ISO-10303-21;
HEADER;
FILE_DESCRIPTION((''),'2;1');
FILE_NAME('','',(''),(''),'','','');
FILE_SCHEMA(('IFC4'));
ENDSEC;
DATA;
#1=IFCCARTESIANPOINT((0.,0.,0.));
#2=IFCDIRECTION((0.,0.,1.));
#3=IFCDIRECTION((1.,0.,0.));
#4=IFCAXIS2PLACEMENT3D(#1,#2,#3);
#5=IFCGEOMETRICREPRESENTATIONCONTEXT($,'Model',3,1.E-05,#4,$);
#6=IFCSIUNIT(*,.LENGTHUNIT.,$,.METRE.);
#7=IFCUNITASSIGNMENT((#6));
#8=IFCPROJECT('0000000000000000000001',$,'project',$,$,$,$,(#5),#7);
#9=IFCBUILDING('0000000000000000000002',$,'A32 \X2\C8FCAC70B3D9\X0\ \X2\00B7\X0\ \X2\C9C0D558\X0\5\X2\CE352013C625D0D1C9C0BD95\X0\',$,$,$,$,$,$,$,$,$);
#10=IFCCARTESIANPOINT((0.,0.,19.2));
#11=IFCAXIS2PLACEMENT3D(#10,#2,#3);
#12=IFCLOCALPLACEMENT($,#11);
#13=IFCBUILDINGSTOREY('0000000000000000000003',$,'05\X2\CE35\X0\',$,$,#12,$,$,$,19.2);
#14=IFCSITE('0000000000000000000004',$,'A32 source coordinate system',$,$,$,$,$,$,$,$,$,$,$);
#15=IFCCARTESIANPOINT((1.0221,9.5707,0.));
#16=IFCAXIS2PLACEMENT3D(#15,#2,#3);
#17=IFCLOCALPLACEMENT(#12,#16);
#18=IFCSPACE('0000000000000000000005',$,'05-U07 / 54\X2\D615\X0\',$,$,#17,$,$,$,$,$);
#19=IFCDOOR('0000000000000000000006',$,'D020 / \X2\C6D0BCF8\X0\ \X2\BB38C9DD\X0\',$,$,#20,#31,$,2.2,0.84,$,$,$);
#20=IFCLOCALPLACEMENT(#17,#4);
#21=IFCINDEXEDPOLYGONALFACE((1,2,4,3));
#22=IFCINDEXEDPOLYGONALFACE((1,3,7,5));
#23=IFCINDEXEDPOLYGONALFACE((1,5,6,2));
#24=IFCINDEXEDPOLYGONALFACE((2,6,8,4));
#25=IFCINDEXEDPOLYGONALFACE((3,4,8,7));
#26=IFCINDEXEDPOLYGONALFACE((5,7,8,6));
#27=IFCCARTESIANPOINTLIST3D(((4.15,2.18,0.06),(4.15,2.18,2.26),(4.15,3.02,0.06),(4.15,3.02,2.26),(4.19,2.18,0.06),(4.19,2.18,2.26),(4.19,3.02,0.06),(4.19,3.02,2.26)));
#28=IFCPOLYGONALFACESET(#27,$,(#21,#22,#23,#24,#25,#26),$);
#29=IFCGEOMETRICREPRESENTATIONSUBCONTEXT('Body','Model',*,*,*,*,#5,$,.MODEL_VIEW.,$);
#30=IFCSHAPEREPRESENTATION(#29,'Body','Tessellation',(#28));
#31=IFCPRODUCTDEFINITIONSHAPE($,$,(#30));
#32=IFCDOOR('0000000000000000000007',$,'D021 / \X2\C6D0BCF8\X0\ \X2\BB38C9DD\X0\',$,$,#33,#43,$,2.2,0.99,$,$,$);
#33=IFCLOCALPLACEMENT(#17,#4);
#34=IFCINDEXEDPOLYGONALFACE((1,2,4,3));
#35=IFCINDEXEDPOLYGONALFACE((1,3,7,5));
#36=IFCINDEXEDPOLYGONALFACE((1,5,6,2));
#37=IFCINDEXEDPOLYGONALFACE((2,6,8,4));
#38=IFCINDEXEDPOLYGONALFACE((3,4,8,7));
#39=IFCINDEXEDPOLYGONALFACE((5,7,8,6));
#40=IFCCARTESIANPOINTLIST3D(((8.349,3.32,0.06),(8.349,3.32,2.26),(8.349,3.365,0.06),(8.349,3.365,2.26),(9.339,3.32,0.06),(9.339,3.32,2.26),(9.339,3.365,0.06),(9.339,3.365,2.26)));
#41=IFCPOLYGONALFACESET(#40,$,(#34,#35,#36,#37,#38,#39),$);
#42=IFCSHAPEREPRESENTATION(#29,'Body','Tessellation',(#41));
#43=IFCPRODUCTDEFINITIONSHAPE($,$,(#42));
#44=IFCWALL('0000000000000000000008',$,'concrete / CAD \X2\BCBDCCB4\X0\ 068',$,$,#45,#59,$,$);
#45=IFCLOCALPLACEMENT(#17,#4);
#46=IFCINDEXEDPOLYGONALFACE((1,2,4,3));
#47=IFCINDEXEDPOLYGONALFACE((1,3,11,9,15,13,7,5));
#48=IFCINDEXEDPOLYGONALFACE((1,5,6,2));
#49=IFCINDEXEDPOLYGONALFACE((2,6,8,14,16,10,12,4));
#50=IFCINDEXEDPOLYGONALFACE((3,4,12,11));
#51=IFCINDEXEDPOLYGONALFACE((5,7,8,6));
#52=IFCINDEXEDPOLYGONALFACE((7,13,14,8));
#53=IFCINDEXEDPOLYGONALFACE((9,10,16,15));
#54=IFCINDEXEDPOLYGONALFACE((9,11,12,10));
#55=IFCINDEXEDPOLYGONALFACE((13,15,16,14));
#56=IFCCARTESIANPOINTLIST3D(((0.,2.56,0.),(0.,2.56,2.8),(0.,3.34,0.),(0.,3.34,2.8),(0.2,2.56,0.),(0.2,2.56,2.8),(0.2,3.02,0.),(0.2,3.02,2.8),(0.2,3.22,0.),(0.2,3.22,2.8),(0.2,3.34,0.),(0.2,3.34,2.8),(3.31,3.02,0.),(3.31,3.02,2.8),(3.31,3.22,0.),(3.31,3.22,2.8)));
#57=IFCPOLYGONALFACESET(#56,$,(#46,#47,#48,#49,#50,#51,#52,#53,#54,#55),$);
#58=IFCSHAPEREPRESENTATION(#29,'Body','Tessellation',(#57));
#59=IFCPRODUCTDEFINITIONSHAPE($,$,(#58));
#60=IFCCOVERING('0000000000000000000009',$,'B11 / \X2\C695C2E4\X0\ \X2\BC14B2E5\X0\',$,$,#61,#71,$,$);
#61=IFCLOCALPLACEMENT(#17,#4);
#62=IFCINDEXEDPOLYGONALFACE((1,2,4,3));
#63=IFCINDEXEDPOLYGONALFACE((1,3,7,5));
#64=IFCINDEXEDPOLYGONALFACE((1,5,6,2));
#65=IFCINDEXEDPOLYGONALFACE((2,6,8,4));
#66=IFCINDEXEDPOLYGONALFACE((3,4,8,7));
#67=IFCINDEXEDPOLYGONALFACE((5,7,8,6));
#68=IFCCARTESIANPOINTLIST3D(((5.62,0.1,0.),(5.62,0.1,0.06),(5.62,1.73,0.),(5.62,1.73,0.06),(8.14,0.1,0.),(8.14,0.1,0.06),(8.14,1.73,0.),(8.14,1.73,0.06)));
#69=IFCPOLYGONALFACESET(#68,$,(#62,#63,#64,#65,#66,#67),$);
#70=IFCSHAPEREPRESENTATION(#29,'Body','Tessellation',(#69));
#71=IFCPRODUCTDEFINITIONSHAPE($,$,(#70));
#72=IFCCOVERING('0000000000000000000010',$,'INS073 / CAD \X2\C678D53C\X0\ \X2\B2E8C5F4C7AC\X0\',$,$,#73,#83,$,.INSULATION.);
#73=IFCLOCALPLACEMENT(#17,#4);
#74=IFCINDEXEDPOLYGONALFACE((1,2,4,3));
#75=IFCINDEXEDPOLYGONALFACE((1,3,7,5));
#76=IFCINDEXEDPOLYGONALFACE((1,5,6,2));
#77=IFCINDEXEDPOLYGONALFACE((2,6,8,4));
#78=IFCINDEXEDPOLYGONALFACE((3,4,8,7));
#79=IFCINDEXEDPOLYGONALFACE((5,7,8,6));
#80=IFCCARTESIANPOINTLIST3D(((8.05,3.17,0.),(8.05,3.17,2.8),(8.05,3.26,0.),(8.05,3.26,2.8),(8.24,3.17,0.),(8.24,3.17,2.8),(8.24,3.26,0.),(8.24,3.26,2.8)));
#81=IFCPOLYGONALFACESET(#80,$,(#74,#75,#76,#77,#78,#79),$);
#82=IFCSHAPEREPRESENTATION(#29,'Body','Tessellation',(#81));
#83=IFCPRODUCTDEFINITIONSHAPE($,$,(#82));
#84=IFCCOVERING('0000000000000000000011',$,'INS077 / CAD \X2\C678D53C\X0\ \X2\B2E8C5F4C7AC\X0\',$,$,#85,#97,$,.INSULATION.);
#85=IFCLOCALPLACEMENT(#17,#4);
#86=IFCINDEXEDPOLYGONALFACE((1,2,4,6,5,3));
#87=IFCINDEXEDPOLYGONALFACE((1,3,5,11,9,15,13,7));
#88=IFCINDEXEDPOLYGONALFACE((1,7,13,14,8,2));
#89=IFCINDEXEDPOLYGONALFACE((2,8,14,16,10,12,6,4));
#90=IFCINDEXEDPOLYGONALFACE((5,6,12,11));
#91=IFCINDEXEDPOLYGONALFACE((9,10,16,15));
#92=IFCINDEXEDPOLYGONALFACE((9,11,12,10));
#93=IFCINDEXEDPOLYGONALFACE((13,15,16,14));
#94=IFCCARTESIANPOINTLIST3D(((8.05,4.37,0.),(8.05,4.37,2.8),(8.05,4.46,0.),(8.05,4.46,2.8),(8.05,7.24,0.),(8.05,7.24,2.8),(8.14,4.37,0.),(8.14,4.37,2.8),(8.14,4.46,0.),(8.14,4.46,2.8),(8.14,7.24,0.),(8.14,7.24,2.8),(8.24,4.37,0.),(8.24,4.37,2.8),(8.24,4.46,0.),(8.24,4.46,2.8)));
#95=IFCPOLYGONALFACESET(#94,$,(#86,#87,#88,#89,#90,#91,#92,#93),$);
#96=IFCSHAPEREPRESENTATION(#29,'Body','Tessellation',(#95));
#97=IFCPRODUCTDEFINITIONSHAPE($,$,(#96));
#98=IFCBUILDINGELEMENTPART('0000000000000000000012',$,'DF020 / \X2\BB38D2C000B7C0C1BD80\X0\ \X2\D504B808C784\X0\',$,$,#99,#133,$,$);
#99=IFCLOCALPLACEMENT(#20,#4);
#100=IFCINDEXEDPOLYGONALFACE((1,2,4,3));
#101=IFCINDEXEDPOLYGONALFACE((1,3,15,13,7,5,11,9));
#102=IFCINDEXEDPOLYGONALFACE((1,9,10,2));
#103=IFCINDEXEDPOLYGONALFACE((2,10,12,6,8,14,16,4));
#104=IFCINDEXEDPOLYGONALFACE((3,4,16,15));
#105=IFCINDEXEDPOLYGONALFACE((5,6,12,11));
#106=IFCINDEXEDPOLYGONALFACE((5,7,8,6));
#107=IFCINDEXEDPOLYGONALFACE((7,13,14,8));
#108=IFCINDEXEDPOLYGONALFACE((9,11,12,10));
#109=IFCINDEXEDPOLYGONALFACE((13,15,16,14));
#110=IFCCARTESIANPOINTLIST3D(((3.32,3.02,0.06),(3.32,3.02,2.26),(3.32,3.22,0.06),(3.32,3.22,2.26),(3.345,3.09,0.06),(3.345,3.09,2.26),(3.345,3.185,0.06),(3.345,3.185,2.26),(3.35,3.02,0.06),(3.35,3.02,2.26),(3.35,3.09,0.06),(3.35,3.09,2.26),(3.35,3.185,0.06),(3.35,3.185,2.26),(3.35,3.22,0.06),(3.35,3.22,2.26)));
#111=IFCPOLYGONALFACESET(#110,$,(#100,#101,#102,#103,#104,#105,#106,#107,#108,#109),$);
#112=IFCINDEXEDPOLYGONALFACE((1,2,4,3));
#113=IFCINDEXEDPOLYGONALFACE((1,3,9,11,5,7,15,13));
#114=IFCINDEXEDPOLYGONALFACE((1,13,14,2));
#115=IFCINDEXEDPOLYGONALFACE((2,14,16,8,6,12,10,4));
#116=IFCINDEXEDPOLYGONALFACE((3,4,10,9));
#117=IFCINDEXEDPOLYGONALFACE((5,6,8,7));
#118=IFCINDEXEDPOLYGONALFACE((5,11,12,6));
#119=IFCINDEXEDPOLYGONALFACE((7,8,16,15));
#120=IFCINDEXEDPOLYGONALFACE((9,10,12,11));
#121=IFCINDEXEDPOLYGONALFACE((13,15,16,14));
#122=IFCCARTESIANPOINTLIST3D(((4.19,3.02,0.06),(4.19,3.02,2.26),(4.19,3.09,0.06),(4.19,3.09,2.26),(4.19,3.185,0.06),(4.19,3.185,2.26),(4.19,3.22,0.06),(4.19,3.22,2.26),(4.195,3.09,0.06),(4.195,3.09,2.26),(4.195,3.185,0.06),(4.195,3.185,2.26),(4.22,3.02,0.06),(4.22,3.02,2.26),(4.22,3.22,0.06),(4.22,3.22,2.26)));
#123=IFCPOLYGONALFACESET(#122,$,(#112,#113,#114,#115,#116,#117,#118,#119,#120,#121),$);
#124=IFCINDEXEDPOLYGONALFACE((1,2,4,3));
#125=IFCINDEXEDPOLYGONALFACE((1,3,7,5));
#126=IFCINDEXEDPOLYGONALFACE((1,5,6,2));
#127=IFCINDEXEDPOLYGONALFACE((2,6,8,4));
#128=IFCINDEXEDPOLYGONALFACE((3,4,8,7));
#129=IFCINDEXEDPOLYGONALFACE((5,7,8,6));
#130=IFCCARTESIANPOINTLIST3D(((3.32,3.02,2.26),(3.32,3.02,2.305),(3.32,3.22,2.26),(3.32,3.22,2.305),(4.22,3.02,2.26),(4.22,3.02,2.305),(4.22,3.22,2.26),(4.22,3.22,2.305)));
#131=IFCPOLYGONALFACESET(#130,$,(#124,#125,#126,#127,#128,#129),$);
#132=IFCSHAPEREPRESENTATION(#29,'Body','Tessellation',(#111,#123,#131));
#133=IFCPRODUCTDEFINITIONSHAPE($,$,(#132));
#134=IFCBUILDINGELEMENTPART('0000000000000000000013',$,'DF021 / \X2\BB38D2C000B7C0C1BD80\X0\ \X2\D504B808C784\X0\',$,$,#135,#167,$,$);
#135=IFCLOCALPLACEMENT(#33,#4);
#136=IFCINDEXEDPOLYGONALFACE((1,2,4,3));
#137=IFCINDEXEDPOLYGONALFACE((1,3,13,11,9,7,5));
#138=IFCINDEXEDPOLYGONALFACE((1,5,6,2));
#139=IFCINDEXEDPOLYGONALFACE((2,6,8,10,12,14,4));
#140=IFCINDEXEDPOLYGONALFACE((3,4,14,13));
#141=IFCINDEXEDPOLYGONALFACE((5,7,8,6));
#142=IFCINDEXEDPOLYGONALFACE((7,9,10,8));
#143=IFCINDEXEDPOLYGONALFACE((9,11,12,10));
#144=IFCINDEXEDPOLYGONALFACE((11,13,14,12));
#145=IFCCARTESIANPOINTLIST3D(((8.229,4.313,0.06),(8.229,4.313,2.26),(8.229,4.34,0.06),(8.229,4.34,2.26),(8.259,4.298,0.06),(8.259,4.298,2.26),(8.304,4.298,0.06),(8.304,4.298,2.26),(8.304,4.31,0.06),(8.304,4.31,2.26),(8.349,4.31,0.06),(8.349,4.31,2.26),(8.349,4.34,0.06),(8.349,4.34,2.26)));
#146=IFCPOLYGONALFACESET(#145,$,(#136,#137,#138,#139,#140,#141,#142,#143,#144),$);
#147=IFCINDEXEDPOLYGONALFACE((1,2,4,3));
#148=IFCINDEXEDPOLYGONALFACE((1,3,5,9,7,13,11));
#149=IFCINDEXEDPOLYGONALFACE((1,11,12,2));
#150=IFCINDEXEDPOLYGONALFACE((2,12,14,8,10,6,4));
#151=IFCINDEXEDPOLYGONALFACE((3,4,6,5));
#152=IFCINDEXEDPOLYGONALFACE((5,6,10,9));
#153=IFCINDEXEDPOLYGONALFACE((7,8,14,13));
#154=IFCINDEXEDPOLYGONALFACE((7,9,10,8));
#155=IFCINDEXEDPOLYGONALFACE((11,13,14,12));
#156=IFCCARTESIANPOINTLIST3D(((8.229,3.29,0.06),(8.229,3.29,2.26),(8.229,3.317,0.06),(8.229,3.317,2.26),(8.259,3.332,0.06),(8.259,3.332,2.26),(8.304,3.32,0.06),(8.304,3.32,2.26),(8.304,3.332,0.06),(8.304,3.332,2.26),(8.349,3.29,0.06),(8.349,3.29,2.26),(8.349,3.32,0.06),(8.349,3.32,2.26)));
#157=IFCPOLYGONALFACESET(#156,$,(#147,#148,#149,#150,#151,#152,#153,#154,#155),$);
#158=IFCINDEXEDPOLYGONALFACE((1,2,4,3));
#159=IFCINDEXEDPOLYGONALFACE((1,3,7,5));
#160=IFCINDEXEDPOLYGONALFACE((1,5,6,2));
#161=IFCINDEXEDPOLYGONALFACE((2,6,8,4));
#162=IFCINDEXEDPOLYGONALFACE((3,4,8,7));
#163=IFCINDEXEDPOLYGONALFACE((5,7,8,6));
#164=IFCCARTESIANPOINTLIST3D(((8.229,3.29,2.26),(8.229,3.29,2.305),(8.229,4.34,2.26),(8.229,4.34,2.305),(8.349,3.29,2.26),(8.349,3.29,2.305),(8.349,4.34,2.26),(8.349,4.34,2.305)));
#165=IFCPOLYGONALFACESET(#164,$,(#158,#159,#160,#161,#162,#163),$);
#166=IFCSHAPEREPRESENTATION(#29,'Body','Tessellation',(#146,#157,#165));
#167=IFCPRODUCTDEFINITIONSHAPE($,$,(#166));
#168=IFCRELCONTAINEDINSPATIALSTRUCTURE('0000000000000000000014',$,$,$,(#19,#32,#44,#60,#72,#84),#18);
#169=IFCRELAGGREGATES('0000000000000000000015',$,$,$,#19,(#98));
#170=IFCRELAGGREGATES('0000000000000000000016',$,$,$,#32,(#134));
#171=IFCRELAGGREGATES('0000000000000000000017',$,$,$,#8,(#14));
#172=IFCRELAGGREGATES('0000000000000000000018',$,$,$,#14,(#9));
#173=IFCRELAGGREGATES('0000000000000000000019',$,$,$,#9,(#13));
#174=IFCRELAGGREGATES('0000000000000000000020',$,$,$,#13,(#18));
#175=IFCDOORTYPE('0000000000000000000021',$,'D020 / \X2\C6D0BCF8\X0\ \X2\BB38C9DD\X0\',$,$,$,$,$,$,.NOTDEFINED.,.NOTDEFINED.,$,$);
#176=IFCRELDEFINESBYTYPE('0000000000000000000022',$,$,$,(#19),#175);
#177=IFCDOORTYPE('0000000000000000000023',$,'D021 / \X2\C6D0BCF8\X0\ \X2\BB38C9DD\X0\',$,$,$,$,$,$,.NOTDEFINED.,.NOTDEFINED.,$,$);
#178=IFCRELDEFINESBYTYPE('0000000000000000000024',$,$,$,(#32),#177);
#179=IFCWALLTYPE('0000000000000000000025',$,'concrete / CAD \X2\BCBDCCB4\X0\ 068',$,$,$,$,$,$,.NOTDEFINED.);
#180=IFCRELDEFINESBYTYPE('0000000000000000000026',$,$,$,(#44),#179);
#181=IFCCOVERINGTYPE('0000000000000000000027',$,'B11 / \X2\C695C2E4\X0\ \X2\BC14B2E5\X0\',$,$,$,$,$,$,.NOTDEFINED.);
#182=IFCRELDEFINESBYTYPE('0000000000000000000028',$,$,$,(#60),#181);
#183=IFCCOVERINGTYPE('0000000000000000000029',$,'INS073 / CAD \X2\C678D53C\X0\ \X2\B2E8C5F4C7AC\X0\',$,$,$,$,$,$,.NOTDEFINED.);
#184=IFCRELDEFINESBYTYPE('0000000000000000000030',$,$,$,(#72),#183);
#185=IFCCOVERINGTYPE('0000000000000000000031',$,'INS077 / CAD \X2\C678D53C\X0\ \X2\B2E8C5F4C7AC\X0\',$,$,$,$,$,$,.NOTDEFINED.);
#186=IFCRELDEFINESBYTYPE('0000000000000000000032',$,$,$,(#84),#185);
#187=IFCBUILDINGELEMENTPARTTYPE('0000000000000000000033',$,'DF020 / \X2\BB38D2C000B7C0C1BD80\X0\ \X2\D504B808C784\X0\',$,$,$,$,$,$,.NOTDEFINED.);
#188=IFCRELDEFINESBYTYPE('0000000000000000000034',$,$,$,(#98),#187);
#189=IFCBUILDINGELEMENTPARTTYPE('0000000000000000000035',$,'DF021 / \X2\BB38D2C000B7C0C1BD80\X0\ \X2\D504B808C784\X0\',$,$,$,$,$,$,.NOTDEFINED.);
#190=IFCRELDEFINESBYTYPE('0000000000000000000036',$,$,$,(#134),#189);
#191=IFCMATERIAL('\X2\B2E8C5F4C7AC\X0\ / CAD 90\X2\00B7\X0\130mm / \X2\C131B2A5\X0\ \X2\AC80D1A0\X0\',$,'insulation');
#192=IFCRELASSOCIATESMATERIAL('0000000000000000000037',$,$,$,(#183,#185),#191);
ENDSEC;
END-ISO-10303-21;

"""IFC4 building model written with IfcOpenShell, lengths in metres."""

from ifc_helpers import new_model, si_unit, frame, origin, origin_with_axes, place, context, subcontext, project, spatial, polyline, outline, extrude, source, transform, mapped, material, type_object, type_shapes, element, aggregate, save


model = new_model("IFC4")

# Units and contexts
model_context = context("Model", 3, precision=1e-05, world=origin_with_axes())
body_context = subcontext(model_context, "Body", "Model", "MODEL_VIEW")
ifc_project = project(units=[si_unit("LENGTHUNIT", "METRE")], contexts=[model_context])

# Site, building, storey, space
storey_placement = place(None, frame((0.0, 0.0, 19.2), z_axis=(0.0, 0.0, 1.0), x_axis=(1.0, 0.0, 0.0)))
space_placement = place(storey_placement, frame((1.0221, 9.5707, 0.0), z_axis=(0.0, 0.0, 1.0), x_axis=(1.0, 0.0, 0.0)))
site = spatial("IfcSite", under=ifc_project, Name="A32 source coordinate system")
building = spatial("IfcBuilding", under=site, Name="A32 주거동 · 지하5층–옥탑지붕")
storey = spatial("IfcBuildingStorey", under=building, at=storey_placement, Name="05층", Elevation=19.2)
space = spatial("IfcSpace", under=storey, at=space_placement, Name="05-U07 / 54형")

# Doors
door_type_1 = type_object("IfcDoorType", Name="D020 / 원본 문짝", OperationType="NOTDEFINED", PredefinedType="NOTDEFINED")
shared_shape_1 = source(origin(), body_context, "Body", "SweptSolid", [
    extrude(outline(polyline([(4.19, 3.02), (4.19, 2.18), (4.15, 2.18), (4.15, 3.02), (4.19, 3.02)])), frame((0.0, 0.0, 0.06)), (0.0, 0.0, 1.0), 2.2),
])
type_shapes(door_type_1, [shared_shape_1])
door_1_placement = place(space_placement, origin_with_axes())
door_1 = element("IfcDoor", 1, at=door_1_placement, inside=space, type_object=door_type_1, Name="D020 / 원본 문짝", OverallHeight=2.2, OverallWidth=0.84, context=body_context, shape_type="MappedRepresentation", body=[
    mapped(shared_shape_1, transform((0.0, 0.0, 0.0), scale=1.0)),
])
door_type_2 = type_object("IfcDoorType", Name="D021 / 원본 문짝", OperationType="NOTDEFINED", PredefinedType="NOTDEFINED")
shared_shape_2 = source(origin(), body_context, "Body", "SweptSolid", [
    extrude(outline(polyline([(9.339, 3.365), (9.339, 3.32), (8.349, 3.32), (8.349, 3.365), (9.339, 3.365)])), frame((0.0, 0.0, 0.06)), (0.0, 0.0, 1.0), 2.2),
])
type_shapes(door_type_2, [shared_shape_2])
door_2_placement = place(space_placement, origin_with_axes())
door_2 = element("IfcDoor", 2, at=door_2_placement, inside=space, type_object=door_type_2, Name="D021 / 원본 문짝", OverallHeight=2.2, OverallWidth=0.99, context=body_context, shape_type="MappedRepresentation", body=[
    mapped(shared_shape_2, transform((0.0, 0.0, 0.0), scale=1.0)),
])

# Wall
wall_type_1 = type_object("IfcWallType", Name="concrete / CAD 벽체 068", PredefinedType="NOTDEFINED")
shared_shape_3 = source(origin(), body_context, "Body", "SweptSolid", [
    extrude(outline(polyline([(0.2, 3.02), (0.2, 2.56), (0.0, 2.56), (0.0, 3.34), (0.2, 3.34), (0.2, 3.22), (3.31, 3.22), (3.31, 3.02), (0.2, 3.02)])), origin(), (0.0, 0.0, 1.0), 2.8),
])
type_shapes(wall_type_1, [shared_shape_3])
wall_1_placement = place(space_placement, origin_with_axes())
element("IfcWall", 3, at=wall_1_placement, inside=space, type_object=wall_type_1, Name="concrete / CAD 벽체 068", context=body_context, shape_type="MappedRepresentation", body=[
    mapped(shared_shape_3, transform((0.0, 0.0, 0.0), scale=1.0)),
])

# Coverings
covering_type_1 = type_object("IfcCoveringType", Name="B11 / 욕실 바닥", PredefinedType="NOTDEFINED")
shared_shape_4 = source(origin(), body_context, "Body", "SweptSolid", [
    extrude(outline(polyline([(8.14, 1.73), (8.14, 0.1), (5.62, 0.1), (5.62, 1.73), (8.14, 1.73)])), origin(), (0.0, 0.0, 1.0), 0.06),
])
type_shapes(covering_type_1, [shared_shape_4])
covering_1_placement = place(space_placement, origin_with_axes())
element("IfcCovering", 4, at=covering_1_placement, inside=space, type_object=covering_type_1, Name="B11 / 욕실 바닥", context=body_context, shape_type="MappedRepresentation", body=[
    mapped(shared_shape_4, transform((0.0, 0.0, 0.0), scale=1.0)),
])
ifc_material = material(Name="단열재 / CAD 90·130mm / 성능 검토", Category="insulation")
covering_type_2 = type_object("IfcCoveringType", Name="INS073 / CAD 외피 단열재", PredefinedType="NOTDEFINED", material=ifc_material)
shared_shape_5 = source(origin(), body_context, "Body", "SweptSolid", [
    extrude(outline(polyline([(8.05, 3.17), (8.05, 3.26), (8.24, 3.26), (8.24, 3.17), (8.05, 3.17)])), origin(), (0.0, 0.0, 1.0), 2.8),
])
type_shapes(covering_type_2, [shared_shape_5])
covering_2_placement = place(space_placement, origin_with_axes())
element("IfcCovering", 5, at=covering_2_placement, inside=space, type_object=covering_type_2, Name="INS073 / CAD 외피 단열재", PredefinedType="INSULATION", context=body_context, shape_type="MappedRepresentation", body=[
    mapped(shared_shape_5, transform((0.0, 0.0, 0.0), scale=1.0)),
])
covering_type_3 = type_object("IfcCoveringType", Name="INS077 / CAD 외피 단열재", PredefinedType="NOTDEFINED", material=ifc_material)
shared_shape_6 = source(origin(), body_context, "Body", "SweptSolid", [
    extrude(outline(polyline([(8.24, 4.37), (8.14, 4.37), (8.05, 4.37), (8.05, 4.46), (8.05, 7.24), (8.14, 7.24), (8.14, 4.46), (8.24, 4.46), (8.24, 4.37)])), origin(), (0.0, 0.0, 1.0), 2.8),
])
type_shapes(covering_type_3, [shared_shape_6])
covering_3_placement = place(space_placement, origin_with_axes())
element("IfcCovering", 6, at=covering_3_placement, inside=space, type_object=covering_type_3, Name="INS077 / CAD 외피 단열재", PredefinedType="INSULATION", context=body_context, shape_type="MappedRepresentation", body=[
    mapped(shared_shape_6, transform((0.0, 0.0, 0.0), scale=1.0)),
])

# Building element parts
building_element_part_type_1 = type_object("IfcBuildingElementPartType", Name="DF020 / 문틀·상부 프레임", PredefinedType="NOTDEFINED")
shared_shape_7 = source(origin(), body_context, "Body", "SweptSolid", [
    extrude(outline(polyline([(3.32, 3.22), (3.35, 3.22), (3.35, 3.185), (3.345, 3.185), (3.345, 3.09), (3.35, 3.09), (3.35, 3.02), (3.32, 3.02), (3.32, 3.22)])), frame((0.0, 0.0, 0.06)), (0.0, 0.0, 1.0), 2.2),
    extrude(outline(polyline([(4.19, 3.02), (4.19, 3.09), (4.195, 3.09), (4.195, 3.185), (4.19, 3.185), (4.19, 3.22), (4.22, 3.22), (4.22, 3.02), (4.19, 3.02)])), frame((0.0, 0.0, 0.06)), (0.0, 0.0, 1.0), 2.2),
    extrude(outline(polyline([(3.32, 3.02), (3.32, 3.22), (4.22, 3.22), (4.22, 3.02), (3.32, 3.02)])), frame((0.0, 0.0, 2.26)), (0.0, 0.0, 1.0), 0.045),
])
type_shapes(building_element_part_type_1, [shared_shape_7])
building_element_part_1_placement = place(door_1_placement, origin_with_axes())
building_element_part_1 = element("IfcBuildingElementPart", 7, at=building_element_part_1_placement, type_object=building_element_part_type_1, Name="DF020 / 문틀·상부 프레임", context=body_context, shape_type="MappedRepresentation", body=[
    mapped(shared_shape_7, transform((0.0, 0.0, 0.0), scale=1.0)),
])
aggregate(door_1, [building_element_part_1])
building_element_part_type_2 = type_object("IfcBuildingElementPartType", Name="DF021 / 문틀·상부 프레임", PredefinedType="NOTDEFINED")
shared_shape_8 = source(origin(), body_context, "Body", "SweptSolid", [
    extrude(outline(polyline([(8.349, 4.31), (8.304, 4.31), (8.304, 4.298), (8.259, 4.298), (8.229, 4.313), (8.229, 4.34), (8.349, 4.34), (8.349, 4.31)])), frame((0.0, 0.0, 0.06)), (0.0, 0.0, 1.0), 2.2),
    extrude(outline(polyline([(8.229, 3.29), (8.229, 3.317), (8.259, 3.332), (8.304, 3.332), (8.304, 3.32), (8.349, 3.32), (8.349, 3.29), (8.229, 3.29)])), frame((0.0, 0.0, 0.06)), (0.0, 0.0, 1.0), 2.2),
    extrude(outline(polyline([(8.229, 3.29), (8.229, 4.34), (8.349, 4.34), (8.349, 3.29), (8.229, 3.29)])), frame((0.0, 0.0, 2.26)), (0.0, 0.0, 1.0), 0.045),
])
type_shapes(building_element_part_type_2, [shared_shape_8])
building_element_part_2_placement = place(door_2_placement, origin_with_axes())
building_element_part_2 = element("IfcBuildingElementPart", 8, at=building_element_part_2_placement, type_object=building_element_part_type_2, Name="DF021 / 문틀·상부 프레임", context=body_context, shape_type="MappedRepresentation", body=[
    mapped(shared_shape_8, transform((0.0, 0.0, 0.0), scale=1.0)),
])
aggregate(door_2, [building_element_part_2])

save(model, "model.ifc")
